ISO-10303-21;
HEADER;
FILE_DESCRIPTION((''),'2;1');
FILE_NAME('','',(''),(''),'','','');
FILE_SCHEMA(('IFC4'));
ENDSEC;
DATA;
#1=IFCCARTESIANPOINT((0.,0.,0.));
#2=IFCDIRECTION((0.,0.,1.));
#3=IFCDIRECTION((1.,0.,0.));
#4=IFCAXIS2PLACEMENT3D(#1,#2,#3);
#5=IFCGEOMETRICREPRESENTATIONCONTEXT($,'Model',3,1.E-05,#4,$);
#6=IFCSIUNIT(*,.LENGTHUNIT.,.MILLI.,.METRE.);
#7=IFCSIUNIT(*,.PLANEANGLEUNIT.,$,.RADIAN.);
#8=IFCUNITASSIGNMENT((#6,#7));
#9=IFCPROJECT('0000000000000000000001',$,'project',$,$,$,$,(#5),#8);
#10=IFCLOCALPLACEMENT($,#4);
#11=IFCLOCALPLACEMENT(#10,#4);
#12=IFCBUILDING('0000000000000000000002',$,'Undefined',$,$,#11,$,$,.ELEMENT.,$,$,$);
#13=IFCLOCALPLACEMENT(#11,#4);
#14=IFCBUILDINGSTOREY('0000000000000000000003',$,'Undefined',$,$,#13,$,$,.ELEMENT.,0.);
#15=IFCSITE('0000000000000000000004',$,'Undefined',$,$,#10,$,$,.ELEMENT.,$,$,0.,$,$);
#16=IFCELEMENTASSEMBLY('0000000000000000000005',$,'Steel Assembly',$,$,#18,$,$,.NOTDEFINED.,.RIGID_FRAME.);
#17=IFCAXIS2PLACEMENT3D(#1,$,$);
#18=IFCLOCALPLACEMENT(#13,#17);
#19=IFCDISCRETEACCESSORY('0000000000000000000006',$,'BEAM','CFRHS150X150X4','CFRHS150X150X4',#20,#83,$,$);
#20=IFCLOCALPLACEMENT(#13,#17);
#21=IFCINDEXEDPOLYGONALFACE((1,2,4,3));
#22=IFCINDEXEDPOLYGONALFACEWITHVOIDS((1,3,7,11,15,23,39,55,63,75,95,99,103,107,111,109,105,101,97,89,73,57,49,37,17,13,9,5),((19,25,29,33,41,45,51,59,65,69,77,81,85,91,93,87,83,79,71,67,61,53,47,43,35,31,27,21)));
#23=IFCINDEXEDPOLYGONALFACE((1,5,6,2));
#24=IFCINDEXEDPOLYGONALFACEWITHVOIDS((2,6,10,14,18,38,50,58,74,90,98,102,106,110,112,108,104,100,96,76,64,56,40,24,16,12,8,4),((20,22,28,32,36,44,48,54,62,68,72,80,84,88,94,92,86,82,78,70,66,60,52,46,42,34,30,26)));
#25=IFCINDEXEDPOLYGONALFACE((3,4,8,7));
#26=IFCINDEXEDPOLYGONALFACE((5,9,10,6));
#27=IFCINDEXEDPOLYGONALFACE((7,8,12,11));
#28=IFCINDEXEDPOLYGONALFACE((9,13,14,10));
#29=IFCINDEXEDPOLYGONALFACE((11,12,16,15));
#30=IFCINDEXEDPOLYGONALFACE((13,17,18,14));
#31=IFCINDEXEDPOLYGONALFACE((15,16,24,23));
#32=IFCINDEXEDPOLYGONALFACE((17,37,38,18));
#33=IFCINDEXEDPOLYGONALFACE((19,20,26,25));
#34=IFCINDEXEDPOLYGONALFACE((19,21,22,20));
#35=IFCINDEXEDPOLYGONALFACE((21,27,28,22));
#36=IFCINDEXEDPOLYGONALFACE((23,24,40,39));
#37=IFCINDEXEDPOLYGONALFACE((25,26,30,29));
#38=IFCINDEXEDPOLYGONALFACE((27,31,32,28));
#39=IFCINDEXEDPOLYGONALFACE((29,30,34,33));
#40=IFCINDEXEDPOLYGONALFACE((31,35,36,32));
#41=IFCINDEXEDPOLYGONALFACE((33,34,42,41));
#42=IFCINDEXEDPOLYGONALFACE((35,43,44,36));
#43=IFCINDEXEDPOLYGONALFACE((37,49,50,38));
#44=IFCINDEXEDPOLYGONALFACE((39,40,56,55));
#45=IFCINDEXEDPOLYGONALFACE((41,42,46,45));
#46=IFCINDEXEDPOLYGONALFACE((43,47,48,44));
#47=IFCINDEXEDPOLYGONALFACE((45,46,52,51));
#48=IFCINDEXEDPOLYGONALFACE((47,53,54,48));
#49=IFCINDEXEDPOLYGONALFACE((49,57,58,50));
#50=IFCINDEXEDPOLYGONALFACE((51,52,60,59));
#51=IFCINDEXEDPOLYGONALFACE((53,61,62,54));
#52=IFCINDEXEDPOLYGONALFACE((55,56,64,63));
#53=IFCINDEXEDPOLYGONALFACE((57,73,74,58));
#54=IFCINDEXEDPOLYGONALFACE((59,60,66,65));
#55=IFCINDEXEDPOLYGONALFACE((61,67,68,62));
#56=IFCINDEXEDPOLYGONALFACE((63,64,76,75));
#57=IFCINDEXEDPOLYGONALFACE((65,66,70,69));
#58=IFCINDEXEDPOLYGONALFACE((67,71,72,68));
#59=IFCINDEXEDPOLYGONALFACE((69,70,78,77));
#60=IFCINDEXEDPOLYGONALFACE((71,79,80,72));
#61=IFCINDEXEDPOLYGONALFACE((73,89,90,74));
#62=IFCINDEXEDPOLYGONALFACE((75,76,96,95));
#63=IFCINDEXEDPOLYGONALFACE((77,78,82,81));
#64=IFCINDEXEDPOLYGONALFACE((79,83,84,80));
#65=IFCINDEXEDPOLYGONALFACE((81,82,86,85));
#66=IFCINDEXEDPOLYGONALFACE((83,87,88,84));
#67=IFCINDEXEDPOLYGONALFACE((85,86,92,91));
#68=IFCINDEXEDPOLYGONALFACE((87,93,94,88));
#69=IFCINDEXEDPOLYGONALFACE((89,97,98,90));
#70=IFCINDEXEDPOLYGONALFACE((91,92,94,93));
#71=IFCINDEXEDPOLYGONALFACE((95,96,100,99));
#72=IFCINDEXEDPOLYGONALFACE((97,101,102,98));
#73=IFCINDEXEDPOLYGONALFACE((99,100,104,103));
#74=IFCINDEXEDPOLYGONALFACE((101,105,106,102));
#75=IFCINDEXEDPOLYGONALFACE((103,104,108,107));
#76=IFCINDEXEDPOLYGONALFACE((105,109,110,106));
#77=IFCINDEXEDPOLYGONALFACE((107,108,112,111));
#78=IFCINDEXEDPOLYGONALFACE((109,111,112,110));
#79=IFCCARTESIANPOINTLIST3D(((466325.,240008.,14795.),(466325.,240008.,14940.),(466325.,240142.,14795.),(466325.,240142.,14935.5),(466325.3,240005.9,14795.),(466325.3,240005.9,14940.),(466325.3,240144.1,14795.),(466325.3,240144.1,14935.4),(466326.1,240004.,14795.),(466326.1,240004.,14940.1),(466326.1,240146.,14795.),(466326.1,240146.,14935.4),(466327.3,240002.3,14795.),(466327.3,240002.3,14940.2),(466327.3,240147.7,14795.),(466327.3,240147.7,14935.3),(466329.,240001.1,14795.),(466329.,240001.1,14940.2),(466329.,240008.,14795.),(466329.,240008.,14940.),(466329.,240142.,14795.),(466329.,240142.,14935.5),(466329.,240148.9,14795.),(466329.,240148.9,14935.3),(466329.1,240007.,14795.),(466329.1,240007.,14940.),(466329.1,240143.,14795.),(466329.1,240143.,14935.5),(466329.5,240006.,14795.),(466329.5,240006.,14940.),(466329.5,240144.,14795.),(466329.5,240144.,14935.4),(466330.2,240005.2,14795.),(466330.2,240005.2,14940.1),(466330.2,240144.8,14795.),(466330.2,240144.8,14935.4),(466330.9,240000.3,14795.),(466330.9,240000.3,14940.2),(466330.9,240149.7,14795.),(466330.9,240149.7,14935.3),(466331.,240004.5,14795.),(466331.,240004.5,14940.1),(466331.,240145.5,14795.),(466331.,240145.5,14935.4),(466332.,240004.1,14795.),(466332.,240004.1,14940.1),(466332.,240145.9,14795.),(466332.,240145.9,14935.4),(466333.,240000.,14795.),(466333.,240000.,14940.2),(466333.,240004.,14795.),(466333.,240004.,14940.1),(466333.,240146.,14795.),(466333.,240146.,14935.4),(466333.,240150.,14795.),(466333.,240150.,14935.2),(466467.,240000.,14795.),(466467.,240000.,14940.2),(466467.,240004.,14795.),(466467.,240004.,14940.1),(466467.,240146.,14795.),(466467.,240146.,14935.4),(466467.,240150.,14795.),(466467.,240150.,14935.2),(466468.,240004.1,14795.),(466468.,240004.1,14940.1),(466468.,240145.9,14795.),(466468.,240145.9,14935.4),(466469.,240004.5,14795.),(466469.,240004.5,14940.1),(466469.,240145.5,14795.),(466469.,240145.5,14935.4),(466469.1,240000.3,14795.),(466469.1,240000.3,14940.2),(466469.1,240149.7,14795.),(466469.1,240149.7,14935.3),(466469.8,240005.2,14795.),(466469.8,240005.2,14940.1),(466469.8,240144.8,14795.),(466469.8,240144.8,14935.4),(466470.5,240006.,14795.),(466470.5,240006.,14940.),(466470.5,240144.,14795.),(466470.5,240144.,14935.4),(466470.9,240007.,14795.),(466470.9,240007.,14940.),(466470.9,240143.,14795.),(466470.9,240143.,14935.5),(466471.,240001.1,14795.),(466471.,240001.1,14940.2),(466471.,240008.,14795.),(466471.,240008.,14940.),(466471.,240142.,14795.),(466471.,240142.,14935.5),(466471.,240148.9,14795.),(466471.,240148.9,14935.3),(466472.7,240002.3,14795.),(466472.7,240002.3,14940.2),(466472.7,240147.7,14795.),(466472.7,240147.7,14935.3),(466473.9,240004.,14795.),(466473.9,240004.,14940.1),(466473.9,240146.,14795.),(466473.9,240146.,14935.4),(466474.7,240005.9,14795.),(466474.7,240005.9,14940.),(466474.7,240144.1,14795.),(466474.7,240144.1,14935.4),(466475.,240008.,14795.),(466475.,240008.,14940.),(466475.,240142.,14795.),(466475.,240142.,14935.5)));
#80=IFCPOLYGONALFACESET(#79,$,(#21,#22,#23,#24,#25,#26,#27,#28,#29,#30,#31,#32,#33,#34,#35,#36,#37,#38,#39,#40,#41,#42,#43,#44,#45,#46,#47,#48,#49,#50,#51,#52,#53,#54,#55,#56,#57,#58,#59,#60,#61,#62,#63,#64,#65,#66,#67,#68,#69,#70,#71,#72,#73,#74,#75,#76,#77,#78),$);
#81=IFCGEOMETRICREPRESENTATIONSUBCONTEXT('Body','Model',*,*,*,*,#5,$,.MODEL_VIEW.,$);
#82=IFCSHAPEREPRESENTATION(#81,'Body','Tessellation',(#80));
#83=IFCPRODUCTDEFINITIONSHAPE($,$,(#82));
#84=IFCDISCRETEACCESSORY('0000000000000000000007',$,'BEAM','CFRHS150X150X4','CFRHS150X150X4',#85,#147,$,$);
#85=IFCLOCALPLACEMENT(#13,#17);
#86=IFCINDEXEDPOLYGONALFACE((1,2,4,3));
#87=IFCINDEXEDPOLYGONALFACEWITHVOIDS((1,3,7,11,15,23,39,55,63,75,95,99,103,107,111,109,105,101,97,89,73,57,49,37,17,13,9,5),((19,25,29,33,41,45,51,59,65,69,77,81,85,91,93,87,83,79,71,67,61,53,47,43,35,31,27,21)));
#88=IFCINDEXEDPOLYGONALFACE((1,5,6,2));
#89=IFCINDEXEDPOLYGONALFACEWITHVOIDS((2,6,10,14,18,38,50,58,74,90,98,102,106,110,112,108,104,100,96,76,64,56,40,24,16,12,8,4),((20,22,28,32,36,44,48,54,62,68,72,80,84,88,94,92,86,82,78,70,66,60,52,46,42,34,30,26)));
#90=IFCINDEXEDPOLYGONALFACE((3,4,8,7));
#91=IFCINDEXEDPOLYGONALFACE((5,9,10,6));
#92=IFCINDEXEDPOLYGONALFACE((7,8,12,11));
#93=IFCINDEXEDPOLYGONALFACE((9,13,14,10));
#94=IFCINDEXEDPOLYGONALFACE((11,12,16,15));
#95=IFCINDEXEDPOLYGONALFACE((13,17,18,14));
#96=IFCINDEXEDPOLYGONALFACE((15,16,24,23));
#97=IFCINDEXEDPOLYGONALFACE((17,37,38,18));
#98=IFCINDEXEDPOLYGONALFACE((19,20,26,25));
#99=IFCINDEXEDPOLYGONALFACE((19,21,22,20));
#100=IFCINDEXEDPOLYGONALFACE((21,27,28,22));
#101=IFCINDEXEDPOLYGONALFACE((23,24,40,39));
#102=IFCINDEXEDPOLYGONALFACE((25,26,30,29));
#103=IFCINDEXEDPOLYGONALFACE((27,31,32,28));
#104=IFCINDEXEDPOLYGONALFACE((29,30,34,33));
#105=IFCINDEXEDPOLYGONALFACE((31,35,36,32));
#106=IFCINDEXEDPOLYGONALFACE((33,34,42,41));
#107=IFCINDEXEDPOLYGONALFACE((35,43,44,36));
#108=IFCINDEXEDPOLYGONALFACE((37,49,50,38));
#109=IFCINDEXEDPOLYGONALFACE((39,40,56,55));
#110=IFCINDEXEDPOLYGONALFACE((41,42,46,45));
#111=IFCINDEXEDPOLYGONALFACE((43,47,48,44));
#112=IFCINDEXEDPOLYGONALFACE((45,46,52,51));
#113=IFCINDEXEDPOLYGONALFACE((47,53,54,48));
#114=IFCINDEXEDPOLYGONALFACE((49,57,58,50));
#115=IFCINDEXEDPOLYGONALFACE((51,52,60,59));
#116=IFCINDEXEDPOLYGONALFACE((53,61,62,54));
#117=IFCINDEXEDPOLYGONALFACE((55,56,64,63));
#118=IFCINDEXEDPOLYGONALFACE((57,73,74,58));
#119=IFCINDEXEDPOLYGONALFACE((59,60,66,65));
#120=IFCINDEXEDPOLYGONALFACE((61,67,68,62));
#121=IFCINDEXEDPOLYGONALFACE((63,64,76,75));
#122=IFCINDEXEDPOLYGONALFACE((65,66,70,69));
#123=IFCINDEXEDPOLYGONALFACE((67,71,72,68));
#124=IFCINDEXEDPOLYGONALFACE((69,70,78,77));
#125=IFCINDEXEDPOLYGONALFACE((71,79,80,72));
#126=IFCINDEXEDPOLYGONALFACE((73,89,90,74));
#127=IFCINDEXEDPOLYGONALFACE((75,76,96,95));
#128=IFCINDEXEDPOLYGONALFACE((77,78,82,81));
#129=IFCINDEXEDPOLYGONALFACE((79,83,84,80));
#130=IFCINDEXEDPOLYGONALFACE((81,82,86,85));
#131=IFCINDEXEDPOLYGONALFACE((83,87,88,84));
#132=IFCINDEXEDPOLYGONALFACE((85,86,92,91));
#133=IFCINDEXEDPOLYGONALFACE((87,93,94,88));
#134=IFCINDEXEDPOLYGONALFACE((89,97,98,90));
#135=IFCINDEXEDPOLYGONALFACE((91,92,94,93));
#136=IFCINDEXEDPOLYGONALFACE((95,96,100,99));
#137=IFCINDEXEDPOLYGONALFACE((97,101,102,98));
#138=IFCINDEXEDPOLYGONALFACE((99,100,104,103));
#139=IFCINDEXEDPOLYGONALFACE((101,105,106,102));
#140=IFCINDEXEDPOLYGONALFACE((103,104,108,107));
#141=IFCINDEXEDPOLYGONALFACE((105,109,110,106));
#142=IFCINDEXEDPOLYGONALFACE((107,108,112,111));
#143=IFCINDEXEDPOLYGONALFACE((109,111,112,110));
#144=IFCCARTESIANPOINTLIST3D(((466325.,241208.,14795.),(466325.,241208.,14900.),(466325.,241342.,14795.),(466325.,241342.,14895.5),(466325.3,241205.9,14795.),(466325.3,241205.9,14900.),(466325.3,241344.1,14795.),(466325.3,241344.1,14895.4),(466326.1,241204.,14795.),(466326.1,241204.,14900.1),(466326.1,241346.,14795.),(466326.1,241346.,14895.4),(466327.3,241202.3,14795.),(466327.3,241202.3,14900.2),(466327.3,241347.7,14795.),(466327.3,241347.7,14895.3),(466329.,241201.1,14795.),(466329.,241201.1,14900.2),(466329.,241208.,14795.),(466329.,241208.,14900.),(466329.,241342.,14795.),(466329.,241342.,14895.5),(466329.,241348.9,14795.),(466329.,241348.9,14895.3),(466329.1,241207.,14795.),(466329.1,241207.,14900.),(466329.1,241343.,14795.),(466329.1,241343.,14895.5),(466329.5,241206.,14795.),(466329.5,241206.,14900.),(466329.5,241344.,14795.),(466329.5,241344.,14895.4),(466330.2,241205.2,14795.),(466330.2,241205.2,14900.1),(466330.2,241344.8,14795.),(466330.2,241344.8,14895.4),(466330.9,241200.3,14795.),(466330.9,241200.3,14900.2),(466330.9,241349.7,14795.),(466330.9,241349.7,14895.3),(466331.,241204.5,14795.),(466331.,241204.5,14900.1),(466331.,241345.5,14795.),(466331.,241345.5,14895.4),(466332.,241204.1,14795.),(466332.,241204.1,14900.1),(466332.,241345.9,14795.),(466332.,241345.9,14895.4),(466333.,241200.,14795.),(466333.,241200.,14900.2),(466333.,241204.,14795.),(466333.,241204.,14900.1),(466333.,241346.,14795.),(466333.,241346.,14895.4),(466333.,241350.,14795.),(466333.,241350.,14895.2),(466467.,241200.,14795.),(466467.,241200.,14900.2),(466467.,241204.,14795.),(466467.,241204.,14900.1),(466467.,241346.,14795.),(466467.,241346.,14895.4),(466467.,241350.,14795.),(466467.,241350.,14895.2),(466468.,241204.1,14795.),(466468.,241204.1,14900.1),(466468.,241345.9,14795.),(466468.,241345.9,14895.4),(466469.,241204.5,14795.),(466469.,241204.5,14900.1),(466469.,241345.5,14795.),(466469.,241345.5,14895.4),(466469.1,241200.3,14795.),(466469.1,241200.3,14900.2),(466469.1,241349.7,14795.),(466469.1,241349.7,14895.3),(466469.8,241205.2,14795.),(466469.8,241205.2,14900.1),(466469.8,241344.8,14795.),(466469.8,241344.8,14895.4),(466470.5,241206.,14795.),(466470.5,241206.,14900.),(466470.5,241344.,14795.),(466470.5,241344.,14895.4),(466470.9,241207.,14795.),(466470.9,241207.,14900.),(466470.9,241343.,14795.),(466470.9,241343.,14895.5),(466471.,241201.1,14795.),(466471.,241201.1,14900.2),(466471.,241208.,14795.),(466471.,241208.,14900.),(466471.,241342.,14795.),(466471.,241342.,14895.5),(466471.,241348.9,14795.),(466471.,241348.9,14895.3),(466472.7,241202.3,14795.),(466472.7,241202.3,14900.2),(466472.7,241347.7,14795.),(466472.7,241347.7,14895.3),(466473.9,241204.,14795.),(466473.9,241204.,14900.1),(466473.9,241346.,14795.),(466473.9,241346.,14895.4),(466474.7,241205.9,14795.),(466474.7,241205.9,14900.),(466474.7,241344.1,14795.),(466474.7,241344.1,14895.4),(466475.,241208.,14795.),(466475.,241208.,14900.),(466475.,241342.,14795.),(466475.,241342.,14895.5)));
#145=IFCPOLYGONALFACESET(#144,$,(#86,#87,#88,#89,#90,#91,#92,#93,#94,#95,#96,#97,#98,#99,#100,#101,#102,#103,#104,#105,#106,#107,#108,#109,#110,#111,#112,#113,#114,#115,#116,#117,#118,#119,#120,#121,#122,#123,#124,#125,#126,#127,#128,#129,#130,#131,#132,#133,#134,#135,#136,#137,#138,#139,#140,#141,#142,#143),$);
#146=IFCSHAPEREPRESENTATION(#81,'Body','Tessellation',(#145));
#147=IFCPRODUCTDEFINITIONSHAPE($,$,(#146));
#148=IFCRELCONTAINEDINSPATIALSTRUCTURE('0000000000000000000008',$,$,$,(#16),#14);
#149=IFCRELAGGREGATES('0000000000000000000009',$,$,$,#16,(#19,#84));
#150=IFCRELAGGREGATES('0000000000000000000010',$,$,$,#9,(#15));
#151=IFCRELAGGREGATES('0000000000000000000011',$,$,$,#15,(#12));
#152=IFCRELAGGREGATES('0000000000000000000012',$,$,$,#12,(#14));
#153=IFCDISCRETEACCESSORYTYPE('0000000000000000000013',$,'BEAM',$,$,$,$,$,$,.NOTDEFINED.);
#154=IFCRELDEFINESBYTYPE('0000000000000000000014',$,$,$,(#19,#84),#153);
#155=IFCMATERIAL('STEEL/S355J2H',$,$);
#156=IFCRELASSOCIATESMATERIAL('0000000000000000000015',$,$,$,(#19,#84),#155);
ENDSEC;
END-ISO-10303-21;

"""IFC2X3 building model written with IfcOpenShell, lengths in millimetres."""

from ifc_helpers import new_model, si_unit, frame, origin_with_axes, origin_2d_with_axis, place, context, subcontext, project, spatial, hollow_rectangle, extrude, clip, halfspace, material, type_object, element, aggregate, save


model = new_model("IFC2X3")

# Units and contexts
model_context = context("Model", 3, precision=1e-05, world=origin_with_axes())
body_context = subcontext(model_context, "Body", "Model", "MODEL_VIEW")
ifc_project = project(units=[si_unit("LENGTHUNIT", "METRE", prefix="MILLI"), si_unit("PLANEANGLEUNIT", "RADIAN")], contexts=[model_context])

# Site, building, storey
site_placement = place(None, origin_with_axes())
site = spatial("IfcSite", under=ifc_project, at=site_placement, Name="Undefined", CompositionType="ELEMENT", RefElevation=0.0)
building_placement = place(site_placement, origin_with_axes())
building = spatial("IfcBuilding", under=site, at=building_placement, Name="Undefined", CompositionType="ELEMENT")
storey_placement = place(building_placement, origin_with_axes())
storey = spatial("IfcBuildingStorey", under=building, at=storey_placement, Name="Undefined", CompositionType="ELEMENT", Elevation=0.0)

# Shared definitions
ifc_material_1 = material(Name="STEEL/S355J2H")

# Element assembly, discrete accessories
assembly_1_placement = place(storey_placement, origin_with_axes())
assembly_1 = element("IfcElementAssembly", 1, at=assembly_1_placement, inside=storey, Name="Steel Assembly", AssemblyPlace="NOTDEFINED", PredefinedType="RIGID_FRAME")
discrete_accessory_type_1 = type_object("IfcDiscreteAccessoryType", Name="BEAM")
discrete_accessory_1_placement = place(assembly_1_placement, frame((466400.0, 240075.0, 14720.0), z_axis=(0.0, 0.0, 1.0), x_axis=(1.0, 0.0, 0.0)))
discrete_accessory_1 = element("IfcDiscreteAccessory", 2, at=discrete_accessory_1_placement, type_object=discrete_accessory_type_1, material=ifc_material_1, Name="BEAM", Description="CFRHS150X150X4", ObjectType="CFRHS150X150X4", context=body_context, shape_type="Clipping", body=[
    clip(extrude(hollow_rectangle(XDim=150.0, YDim=150.0, WallThickness=4.0, InnerFilletRadius=4.0, OuterFilletRadius=8.0, at=origin_2d_with_axis()), frame((0.0, 0.0, 220.3), z_axis=(0.0, 0.0, -1.0), x_axis=(0.0, -1.0, 0.0)), (0.0, 0.0, 1.0), 145.3), halfspace(frame((-1000.0, -2.7, 217.8), z_axis=(0.0, -0.033315, -0.999445), x_axis=(0.0, -0.999445, 0.033315)), True)),
])
discrete_accessory_2_placement = place(assembly_1_placement, frame((466400.0, 241275.0, 14720.0), z_axis=(0.0, 0.0, 1.0), x_axis=(1.0, 0.0, 0.0)))
discrete_accessory_2 = element("IfcDiscreteAccessory", 3, at=discrete_accessory_2_placement, type_object=discrete_accessory_type_1, material=ifc_material_1, Name="BEAM", Description="CFRHS150X150X4", ObjectType="CFRHS150X150X4", context=body_context, shape_type="Clipping", body=[
    clip(extrude(hollow_rectangle(XDim=150.0, YDim=150.0, WallThickness=4.0, InnerFilletRadius=4.0, OuterFilletRadius=8.0, at=origin_2d_with_axis()), frame((0.0, 0.0, 180.3), z_axis=(0.0, 0.0, -1.0), x_axis=(0.0, -1.0, 0.0)), (0.0, 0.0, 1.0), 105.3), halfspace(frame((-1000.0, -2.7, 177.8), z_axis=(0.0, -0.033315, -0.999445), x_axis=(0.0, -0.999445, 0.033315)), True)),
])

aggregate(assembly_1, [discrete_accessory_1, discrete_accessory_2])

save(model, "model.ifc")
